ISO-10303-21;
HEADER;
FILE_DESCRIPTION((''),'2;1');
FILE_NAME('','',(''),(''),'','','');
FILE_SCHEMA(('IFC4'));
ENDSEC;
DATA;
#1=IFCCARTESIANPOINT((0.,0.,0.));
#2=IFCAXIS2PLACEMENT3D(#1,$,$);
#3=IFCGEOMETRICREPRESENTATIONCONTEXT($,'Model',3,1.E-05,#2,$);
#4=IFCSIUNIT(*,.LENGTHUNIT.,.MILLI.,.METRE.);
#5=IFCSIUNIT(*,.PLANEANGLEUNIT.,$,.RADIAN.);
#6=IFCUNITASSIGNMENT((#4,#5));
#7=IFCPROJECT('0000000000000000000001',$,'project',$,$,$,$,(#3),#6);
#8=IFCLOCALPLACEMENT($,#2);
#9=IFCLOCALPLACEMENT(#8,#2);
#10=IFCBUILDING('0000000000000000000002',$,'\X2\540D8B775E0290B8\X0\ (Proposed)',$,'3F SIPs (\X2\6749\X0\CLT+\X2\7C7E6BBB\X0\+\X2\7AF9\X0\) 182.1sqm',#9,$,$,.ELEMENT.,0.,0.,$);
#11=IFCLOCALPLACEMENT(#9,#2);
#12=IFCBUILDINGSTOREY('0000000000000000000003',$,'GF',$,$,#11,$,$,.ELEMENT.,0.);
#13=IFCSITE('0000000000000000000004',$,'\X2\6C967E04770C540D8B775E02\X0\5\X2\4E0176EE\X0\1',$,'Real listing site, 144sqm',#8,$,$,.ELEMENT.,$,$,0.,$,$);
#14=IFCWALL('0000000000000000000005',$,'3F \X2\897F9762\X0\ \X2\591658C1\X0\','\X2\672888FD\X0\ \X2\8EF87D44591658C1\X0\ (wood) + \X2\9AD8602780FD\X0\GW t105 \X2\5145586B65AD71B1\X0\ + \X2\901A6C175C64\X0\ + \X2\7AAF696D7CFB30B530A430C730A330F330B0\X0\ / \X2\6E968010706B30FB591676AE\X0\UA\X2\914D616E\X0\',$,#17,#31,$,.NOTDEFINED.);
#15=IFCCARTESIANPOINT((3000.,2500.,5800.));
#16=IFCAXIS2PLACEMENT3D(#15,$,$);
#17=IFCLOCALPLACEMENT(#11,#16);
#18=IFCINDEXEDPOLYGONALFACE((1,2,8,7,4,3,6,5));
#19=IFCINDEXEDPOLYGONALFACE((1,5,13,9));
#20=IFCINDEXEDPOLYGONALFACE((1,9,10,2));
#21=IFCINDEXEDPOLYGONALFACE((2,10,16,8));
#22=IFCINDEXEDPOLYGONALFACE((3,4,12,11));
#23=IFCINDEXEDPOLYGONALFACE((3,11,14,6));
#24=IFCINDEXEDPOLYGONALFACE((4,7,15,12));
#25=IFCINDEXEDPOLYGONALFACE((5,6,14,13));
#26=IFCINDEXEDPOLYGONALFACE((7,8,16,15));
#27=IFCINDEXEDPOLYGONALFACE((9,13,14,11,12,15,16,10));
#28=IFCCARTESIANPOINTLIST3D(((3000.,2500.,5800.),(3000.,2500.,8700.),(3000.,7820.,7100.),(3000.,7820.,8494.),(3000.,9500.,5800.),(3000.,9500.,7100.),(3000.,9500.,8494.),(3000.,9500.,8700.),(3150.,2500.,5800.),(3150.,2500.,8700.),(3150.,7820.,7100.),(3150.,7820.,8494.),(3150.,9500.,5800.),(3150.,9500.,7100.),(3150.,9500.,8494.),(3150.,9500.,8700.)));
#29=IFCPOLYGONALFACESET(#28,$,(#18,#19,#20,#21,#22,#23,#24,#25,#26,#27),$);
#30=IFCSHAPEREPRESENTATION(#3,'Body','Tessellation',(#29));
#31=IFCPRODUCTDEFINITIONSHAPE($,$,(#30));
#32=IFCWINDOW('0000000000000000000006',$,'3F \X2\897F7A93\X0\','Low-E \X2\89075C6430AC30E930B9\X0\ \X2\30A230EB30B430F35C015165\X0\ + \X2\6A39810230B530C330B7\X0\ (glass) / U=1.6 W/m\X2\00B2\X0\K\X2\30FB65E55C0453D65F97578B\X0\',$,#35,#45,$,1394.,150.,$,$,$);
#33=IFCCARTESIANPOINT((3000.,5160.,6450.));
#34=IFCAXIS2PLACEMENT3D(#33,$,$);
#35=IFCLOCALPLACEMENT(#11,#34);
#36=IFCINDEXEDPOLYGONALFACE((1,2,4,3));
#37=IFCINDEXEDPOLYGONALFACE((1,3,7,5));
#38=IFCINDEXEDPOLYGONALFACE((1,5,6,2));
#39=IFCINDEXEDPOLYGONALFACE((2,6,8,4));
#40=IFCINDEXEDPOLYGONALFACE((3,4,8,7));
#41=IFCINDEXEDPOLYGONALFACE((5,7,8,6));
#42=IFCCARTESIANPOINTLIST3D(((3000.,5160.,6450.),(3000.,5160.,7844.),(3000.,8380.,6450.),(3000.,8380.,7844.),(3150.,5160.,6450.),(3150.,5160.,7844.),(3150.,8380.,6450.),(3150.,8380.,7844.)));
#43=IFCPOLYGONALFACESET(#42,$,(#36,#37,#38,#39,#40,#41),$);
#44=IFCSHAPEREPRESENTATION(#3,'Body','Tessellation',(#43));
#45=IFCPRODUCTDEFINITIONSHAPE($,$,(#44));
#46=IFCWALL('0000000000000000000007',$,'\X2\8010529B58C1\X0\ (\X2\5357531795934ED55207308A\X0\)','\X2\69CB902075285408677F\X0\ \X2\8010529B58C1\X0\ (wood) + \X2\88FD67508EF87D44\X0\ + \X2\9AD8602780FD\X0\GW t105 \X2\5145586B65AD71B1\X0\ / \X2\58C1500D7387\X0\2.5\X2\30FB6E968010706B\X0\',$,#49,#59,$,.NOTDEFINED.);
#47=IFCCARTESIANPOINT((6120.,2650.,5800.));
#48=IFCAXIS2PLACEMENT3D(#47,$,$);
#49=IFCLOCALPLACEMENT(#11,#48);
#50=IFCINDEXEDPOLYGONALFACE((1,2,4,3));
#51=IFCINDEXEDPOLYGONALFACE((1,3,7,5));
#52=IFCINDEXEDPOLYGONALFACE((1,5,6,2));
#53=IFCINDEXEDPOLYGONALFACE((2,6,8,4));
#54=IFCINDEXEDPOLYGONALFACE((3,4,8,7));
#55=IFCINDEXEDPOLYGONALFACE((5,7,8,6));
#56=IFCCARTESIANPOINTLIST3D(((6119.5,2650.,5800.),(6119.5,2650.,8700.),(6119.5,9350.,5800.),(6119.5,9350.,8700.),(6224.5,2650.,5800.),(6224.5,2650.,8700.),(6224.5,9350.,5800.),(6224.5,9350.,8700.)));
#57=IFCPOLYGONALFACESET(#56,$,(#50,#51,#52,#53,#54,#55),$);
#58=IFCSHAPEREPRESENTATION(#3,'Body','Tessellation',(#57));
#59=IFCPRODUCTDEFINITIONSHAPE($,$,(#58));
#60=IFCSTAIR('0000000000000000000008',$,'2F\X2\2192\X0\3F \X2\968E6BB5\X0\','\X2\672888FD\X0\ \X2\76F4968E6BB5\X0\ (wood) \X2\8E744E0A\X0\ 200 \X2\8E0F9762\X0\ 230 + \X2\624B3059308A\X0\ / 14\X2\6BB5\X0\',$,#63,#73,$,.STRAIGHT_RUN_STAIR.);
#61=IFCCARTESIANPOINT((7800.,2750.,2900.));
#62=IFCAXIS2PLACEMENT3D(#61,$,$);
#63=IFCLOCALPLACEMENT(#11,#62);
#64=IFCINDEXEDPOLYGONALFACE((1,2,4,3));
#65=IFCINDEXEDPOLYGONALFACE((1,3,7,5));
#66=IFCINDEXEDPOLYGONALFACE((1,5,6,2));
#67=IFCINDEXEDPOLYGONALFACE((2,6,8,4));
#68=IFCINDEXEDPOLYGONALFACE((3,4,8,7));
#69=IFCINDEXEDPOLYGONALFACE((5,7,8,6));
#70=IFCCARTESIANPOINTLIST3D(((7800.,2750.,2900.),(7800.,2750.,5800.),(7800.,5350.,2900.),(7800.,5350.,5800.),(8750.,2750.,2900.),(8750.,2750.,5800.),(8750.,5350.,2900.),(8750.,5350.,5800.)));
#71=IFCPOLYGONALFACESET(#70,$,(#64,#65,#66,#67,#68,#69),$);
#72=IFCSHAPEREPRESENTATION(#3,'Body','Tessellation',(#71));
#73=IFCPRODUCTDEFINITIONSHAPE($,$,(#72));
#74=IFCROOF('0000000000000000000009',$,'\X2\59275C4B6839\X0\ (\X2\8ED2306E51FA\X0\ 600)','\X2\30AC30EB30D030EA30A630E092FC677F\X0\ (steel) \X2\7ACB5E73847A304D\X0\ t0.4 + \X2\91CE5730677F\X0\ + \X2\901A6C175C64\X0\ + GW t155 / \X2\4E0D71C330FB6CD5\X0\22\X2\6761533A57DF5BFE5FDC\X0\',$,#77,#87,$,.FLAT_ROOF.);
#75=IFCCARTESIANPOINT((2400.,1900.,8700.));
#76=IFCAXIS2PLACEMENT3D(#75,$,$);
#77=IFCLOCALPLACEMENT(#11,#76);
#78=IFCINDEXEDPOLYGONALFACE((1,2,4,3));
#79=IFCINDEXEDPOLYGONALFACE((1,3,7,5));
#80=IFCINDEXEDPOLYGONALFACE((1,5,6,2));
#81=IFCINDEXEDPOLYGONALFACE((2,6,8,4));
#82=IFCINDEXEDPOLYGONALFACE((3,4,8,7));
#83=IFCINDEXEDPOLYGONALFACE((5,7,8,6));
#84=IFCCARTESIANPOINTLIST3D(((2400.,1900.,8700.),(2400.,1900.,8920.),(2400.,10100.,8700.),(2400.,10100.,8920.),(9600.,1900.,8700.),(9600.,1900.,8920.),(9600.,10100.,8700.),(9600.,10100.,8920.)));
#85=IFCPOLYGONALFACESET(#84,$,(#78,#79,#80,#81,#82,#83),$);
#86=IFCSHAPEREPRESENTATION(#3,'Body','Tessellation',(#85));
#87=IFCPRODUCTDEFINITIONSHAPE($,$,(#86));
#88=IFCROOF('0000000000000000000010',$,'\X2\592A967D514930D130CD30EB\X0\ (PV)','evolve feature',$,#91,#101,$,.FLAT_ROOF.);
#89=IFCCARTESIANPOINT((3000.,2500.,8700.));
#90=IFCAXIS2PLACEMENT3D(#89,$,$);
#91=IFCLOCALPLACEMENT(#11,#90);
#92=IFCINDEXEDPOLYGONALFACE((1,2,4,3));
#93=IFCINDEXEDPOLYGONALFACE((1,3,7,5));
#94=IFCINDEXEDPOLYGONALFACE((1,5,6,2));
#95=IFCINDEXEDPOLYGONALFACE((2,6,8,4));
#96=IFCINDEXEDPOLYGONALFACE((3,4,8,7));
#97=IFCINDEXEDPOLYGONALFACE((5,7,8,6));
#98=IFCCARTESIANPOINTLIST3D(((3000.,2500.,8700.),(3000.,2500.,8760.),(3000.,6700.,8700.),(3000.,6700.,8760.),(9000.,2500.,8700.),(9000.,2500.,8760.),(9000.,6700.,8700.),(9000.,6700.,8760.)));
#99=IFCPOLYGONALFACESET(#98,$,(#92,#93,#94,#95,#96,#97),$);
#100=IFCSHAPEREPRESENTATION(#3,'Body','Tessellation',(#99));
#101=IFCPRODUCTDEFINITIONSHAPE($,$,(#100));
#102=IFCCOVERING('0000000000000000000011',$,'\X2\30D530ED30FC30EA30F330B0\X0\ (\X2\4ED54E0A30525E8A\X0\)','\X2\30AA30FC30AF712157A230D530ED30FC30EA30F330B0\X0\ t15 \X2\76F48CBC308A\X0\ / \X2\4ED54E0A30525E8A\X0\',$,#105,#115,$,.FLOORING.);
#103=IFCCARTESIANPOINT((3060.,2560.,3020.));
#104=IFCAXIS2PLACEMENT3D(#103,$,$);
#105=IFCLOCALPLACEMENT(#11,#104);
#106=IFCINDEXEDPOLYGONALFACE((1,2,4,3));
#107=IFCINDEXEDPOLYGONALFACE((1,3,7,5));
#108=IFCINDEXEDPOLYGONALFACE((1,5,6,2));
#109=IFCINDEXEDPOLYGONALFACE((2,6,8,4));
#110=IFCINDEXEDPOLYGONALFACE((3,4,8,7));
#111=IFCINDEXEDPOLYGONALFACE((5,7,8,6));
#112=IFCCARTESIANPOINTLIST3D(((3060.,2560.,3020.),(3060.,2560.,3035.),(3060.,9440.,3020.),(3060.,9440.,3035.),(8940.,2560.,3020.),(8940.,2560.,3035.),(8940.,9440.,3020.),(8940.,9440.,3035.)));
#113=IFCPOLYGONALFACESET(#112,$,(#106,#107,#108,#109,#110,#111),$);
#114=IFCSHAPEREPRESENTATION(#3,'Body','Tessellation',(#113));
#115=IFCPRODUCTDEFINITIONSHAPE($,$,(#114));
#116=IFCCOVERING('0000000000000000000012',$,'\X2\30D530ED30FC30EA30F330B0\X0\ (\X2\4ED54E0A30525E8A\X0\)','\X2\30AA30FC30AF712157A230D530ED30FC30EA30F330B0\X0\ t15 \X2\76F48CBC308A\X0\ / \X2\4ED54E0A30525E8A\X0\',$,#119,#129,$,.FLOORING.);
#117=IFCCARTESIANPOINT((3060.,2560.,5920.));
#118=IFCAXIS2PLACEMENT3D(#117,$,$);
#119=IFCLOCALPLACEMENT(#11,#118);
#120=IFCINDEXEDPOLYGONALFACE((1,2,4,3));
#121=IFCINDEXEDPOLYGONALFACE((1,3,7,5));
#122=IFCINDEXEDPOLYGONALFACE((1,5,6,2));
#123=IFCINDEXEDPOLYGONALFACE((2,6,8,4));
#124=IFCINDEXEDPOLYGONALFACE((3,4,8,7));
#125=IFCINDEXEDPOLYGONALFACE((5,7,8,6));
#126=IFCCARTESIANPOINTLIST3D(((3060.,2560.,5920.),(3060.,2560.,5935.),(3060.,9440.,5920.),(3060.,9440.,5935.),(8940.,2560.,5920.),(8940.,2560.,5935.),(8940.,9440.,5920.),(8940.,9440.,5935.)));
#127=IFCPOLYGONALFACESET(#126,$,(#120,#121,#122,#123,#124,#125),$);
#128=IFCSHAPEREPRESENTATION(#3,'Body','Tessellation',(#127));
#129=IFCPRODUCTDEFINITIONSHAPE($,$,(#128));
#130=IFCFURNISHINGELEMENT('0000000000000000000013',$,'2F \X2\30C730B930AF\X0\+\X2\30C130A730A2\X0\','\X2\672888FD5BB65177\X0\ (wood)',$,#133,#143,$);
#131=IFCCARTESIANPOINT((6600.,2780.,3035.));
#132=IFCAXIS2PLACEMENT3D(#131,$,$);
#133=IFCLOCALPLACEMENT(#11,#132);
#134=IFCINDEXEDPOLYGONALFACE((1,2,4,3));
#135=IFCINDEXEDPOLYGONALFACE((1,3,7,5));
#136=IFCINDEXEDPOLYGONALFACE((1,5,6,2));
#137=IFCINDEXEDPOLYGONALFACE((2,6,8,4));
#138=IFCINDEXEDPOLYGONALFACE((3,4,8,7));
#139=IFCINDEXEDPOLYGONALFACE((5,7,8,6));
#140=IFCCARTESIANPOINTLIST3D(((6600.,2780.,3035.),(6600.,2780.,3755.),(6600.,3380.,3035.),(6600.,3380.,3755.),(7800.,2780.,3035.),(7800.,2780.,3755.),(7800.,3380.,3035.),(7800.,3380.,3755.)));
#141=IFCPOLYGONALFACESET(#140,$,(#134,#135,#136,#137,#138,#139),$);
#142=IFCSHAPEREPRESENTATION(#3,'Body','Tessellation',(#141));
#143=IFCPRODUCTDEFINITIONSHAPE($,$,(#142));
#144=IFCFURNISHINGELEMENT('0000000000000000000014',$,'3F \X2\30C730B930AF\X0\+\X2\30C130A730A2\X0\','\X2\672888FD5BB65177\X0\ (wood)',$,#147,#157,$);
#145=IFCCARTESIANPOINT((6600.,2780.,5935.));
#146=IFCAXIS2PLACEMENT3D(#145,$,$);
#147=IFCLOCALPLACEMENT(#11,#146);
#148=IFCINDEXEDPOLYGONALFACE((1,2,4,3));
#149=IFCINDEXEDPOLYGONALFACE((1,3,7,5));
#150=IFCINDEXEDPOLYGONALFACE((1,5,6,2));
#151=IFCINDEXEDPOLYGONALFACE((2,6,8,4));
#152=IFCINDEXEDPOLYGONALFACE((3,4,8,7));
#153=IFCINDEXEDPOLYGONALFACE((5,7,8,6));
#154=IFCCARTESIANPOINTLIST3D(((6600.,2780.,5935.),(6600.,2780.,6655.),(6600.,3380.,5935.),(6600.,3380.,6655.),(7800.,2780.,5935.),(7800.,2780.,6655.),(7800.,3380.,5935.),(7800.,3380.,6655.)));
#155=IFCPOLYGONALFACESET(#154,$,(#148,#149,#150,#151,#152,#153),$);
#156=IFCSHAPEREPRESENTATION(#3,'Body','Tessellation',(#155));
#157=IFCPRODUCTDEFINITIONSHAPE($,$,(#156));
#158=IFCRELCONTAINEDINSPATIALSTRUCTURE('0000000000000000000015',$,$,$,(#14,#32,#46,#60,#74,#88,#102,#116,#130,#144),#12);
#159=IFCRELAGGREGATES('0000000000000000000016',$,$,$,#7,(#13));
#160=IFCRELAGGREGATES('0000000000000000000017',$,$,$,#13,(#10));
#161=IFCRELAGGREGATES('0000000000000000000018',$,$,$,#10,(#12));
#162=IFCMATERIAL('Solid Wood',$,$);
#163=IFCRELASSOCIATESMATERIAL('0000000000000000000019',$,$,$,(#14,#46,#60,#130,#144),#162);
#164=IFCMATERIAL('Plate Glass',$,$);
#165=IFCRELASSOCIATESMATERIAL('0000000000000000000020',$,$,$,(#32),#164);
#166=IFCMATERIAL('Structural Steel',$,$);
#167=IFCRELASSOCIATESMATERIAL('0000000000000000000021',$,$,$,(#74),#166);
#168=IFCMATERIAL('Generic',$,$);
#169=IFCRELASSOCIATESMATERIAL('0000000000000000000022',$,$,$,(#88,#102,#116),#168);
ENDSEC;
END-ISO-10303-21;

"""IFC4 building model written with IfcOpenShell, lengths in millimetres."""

from ifc_helpers import new_model, si_unit, frame, frame_2d, origin, place, context, project, spatial, rectangle, extrude, material, element, fill, save


model = new_model("IFC4")

# Units and contexts
model_context = context("Model", 3, precision=1e-05, world=origin())
ifc_project = project(units=[si_unit("LENGTHUNIT", "METRE", prefix="MILLI"), si_unit("PLANEANGLEUNIT", "RADIAN")], contexts=[model_context])

# Site, building, storey
site_placement = place(None, origin())
site = spatial("IfcSite", under=ifc_project, at=site_placement, Name="沖縄県名護市5丁目1", ObjectType="Real listing site, 144sqm", CompositionType="ELEMENT", RefElevation=0.0)
building_placement = place(site_placement, origin())
building = spatial("IfcBuilding", under=site, at=building_placement, Name="名護市邸 (Proposed)", ObjectType="3F SIPs (杉CLT+籾殻+竹) 182.1sqm", CompositionType="ELEMENT", ElevationOfRefHeight=0.0, ElevationOfTerrain=0.0)
storey_placement = place(building_placement, origin())
storey = spatial("IfcBuildingStorey", under=building, at=storey_placement, Name="GF", CompositionType="ELEMENT", Elevation=0.0)

# Shared definitions
ifc_material_1 = material(Name="Solid Wood")

# Shared definitions
ifc_material_2 = material(Name="Plate Glass")

# Shared definitions
ifc_material_3 = material(Name="Generic")

# Wall, opening, window
wall_1_placement = place(storey_placement, frame((3000.0, 2500.0, 5800.0)))
wall_1 = element("IfcWall", 1, at=wall_1_placement, inside=storey, material=ifc_material_1, Name="3F 西面 外壁", Description="木製 軸組外壁 (wood) + 高性能GW t105 充填断熱 + 通気層 + 窯業系サイディング / 準耐火・外皮UA配慮", PredefinedType="NOTDEFINED", context=model_context, shape_type="SweptSolid", body=[
    extrude(rectangle(XDim=150.0, YDim=7000.0, at=frame_2d((75.0, 3500.0))), frame((3000.0, 2500.0, 5800.0)), (0.0, 0.0, 1.0), 2900.0),
])
opening_1_placement = place(storey_placement, frame((3000.0, 5160.0, 6450.0)))
opening_1 = element("IfcOpeningElement", 2, at=opening_1_placement, cuts=wall_1, PredefinedType="NOTDEFINED", context=model_context, shape_type="SweptSolid", body=[
    extrude(rectangle(XDim=150.0, YDim=3220.0, at=frame_2d((75.0, 1610.0))), frame((3000.0, 5160.0, 6450.0)), (0.0, 0.0, 1.0), 1394.0),
])
window_1_placement = place(storey_placement, frame((3000.0, 5160.0, 6450.0)))
window_1 = element("IfcWindow", 3, at=window_1_placement, inside=storey, material=ifc_material_2, Name="3F 西窓", Description="Low-E 複層ガラス アルゴン封入 + 樹脂サッシ (glass) / U=1.6 W/m²K・日射取得型", OverallHeight=1394.0, OverallWidth=150.0, context=model_context, shape_type="SweptSolid", body=[
    extrude(rectangle(XDim=150.0, YDim=3220.0, at=frame_2d((75.0, 1610.0))), frame((3000.0, 5160.0, 6450.0)), (0.0, 0.0, 1.0), 1394.0),
])
fill(opening_1, window_1)

# Wall
wall_2_placement = place(storey_placement, frame((6120.0, 2650.0, 5800.0)))
element("IfcWall", 4, at=wall_2_placement, inside=storey, material=ifc_material_1, Name="耐力壁 (南北間仕切り)", Description="構造用合板 耐力壁 (wood) + 製材軸組 + 高性能GW t105 充填断熱 / 壁倍率2.5・準耐火", PredefinedType="NOTDEFINED", context=model_context, shape_type="SweptSolid", body=[
    extrude(rectangle(XDim=105.0, YDim=6700.0, at=frame_2d((52.0, 3350.0))), frame((6120.0, 2650.0, 5800.0)), (0.0, 0.0, 1.0), 2900.0),
])

# Stair
stair_placement = place(storey_placement, frame((7800.0, 2750.0, 2900.0)))
element("IfcStair", 5, at=stair_placement, inside=storey, material=ifc_material_1, Name="2F→3F 階段", Description="木製 直階段 (wood) 蹴上 200 踏面 230 + 手すり / 14段", PredefinedType="STRAIGHT_RUN_STAIR", context=model_context, shape_type="SweptSolid", body=[
    extrude(rectangle(XDim=950.0, YDim=2600.0, at=frame_2d((475.0, 1300.0))), frame((7800.0, 2750.0, 2900.0)), (0.0, 0.0, 1.0), 2900.0),
])

# Roofs
ifc_material_4 = material(Name="Structural Steel")
roof_1_placement = place(storey_placement, frame((2400.0, 1900.0, 8700.0)))
element("IfcRoof", 6, at=roof_1_placement, inside=storey, material=ifc_material_4, Name="大屋根 (軒の出 600)", Description="ガルバリウム鋼板 (steel) 立平葺き t0.4 + 野地板 + 通気層 + GW t155 / 不燃・法22条区域対応", PredefinedType="FLAT_ROOF", context=model_context, shape_type="SweptSolid", body=[
    extrude(rectangle(XDim=7200.0, YDim=8200.0, at=frame_2d((3600.0, 4100.0))), frame((2400.0, 1900.0, 8700.0)), (0.0, 0.0, 1.0), 220.0),
])
roof_2_placement = place(storey_placement, frame((3000.0, 2500.0, 8700.0)))
element("IfcRoof", 7, at=roof_2_placement, inside=storey, material=ifc_material_3, Name="太陽光パネル (PV)", Description="evolve feature", PredefinedType="FLAT_ROOF", context=model_context, shape_type="SweptSolid", body=[
    extrude(rectangle(XDim=6000.0, YDim=4200.0, at=frame_2d((3000.0, 2100.0))), frame((3000.0, 2500.0, 8700.0)), (0.0, 0.0, 1.0), 60.0),
])

# Coverings
covering_1_placement = place(storey_placement, frame((3060.0, 2560.0, 3020.0)))
element("IfcCovering", 8, at=covering_1_placement, inside=storey, material=ifc_material_3, Name="フローリング (仕上げ床)", Description="オーク無垢フローリング t15 直貼り / 仕上げ床", PredefinedType="FLOORING", context=model_context, shape_type="SweptSolid", body=[
    extrude(rectangle(XDim=5880.0, YDim=6880.0, at=frame_2d((2940.0, 3440.0))), frame((3060.0, 2560.0, 3020.0)), (0.0, 0.0, 1.0), 15.0),
])
covering_2_placement = place(storey_placement, frame((3060.0, 2560.0, 5920.0)))
element("IfcCovering", 9, at=covering_2_placement, inside=storey, material=ifc_material_3, Name="フローリング (仕上げ床)", Description="オーク無垢フローリング t15 直貼り / 仕上げ床", PredefinedType="FLOORING", context=model_context, shape_type="SweptSolid", body=[
    extrude(rectangle(XDim=5880.0, YDim=6880.0, at=frame_2d((2940.0, 3440.0))), frame((3060.0, 2560.0, 5920.0)), (0.0, 0.0, 1.0), 15.0),
])

# Furnishing elements
furnishing_1_placement = place(storey_placement, frame((6600.0, 2780.0, 3035.0)))
element("IfcFurnishingElement", 10, at=furnishing_1_placement, inside=storey, material=ifc_material_1, Name="2F デスク+チェア", Description="木製家具 (wood)", context=model_context, shape_type="SweptSolid", body=[
    extrude(rectangle(XDim=1200.0, YDim=600.0, at=frame_2d((600.0, 300.0))), frame((6600.0, 2780.0, 3035.0)), (0.0, 0.0, 1.0), 720.0),
])
furnishing_2_placement = place(storey_placement, frame((6600.0, 2780.0, 5935.0)))
element("IfcFurnishingElement", 11, at=furnishing_2_placement, inside=storey, material=ifc_material_1, Name="3F デスク+チェア", Description="木製家具 (wood)", context=model_context, shape_type="SweptSolid", body=[
    extrude(rectangle(XDim=1200.0, YDim=600.0, at=frame_2d((600.0, 300.0))), frame((6600.0, 2780.0, 5935.0)), (0.0, 0.0, 1.0), 720.0),
])

save(model, "model.ifc")
